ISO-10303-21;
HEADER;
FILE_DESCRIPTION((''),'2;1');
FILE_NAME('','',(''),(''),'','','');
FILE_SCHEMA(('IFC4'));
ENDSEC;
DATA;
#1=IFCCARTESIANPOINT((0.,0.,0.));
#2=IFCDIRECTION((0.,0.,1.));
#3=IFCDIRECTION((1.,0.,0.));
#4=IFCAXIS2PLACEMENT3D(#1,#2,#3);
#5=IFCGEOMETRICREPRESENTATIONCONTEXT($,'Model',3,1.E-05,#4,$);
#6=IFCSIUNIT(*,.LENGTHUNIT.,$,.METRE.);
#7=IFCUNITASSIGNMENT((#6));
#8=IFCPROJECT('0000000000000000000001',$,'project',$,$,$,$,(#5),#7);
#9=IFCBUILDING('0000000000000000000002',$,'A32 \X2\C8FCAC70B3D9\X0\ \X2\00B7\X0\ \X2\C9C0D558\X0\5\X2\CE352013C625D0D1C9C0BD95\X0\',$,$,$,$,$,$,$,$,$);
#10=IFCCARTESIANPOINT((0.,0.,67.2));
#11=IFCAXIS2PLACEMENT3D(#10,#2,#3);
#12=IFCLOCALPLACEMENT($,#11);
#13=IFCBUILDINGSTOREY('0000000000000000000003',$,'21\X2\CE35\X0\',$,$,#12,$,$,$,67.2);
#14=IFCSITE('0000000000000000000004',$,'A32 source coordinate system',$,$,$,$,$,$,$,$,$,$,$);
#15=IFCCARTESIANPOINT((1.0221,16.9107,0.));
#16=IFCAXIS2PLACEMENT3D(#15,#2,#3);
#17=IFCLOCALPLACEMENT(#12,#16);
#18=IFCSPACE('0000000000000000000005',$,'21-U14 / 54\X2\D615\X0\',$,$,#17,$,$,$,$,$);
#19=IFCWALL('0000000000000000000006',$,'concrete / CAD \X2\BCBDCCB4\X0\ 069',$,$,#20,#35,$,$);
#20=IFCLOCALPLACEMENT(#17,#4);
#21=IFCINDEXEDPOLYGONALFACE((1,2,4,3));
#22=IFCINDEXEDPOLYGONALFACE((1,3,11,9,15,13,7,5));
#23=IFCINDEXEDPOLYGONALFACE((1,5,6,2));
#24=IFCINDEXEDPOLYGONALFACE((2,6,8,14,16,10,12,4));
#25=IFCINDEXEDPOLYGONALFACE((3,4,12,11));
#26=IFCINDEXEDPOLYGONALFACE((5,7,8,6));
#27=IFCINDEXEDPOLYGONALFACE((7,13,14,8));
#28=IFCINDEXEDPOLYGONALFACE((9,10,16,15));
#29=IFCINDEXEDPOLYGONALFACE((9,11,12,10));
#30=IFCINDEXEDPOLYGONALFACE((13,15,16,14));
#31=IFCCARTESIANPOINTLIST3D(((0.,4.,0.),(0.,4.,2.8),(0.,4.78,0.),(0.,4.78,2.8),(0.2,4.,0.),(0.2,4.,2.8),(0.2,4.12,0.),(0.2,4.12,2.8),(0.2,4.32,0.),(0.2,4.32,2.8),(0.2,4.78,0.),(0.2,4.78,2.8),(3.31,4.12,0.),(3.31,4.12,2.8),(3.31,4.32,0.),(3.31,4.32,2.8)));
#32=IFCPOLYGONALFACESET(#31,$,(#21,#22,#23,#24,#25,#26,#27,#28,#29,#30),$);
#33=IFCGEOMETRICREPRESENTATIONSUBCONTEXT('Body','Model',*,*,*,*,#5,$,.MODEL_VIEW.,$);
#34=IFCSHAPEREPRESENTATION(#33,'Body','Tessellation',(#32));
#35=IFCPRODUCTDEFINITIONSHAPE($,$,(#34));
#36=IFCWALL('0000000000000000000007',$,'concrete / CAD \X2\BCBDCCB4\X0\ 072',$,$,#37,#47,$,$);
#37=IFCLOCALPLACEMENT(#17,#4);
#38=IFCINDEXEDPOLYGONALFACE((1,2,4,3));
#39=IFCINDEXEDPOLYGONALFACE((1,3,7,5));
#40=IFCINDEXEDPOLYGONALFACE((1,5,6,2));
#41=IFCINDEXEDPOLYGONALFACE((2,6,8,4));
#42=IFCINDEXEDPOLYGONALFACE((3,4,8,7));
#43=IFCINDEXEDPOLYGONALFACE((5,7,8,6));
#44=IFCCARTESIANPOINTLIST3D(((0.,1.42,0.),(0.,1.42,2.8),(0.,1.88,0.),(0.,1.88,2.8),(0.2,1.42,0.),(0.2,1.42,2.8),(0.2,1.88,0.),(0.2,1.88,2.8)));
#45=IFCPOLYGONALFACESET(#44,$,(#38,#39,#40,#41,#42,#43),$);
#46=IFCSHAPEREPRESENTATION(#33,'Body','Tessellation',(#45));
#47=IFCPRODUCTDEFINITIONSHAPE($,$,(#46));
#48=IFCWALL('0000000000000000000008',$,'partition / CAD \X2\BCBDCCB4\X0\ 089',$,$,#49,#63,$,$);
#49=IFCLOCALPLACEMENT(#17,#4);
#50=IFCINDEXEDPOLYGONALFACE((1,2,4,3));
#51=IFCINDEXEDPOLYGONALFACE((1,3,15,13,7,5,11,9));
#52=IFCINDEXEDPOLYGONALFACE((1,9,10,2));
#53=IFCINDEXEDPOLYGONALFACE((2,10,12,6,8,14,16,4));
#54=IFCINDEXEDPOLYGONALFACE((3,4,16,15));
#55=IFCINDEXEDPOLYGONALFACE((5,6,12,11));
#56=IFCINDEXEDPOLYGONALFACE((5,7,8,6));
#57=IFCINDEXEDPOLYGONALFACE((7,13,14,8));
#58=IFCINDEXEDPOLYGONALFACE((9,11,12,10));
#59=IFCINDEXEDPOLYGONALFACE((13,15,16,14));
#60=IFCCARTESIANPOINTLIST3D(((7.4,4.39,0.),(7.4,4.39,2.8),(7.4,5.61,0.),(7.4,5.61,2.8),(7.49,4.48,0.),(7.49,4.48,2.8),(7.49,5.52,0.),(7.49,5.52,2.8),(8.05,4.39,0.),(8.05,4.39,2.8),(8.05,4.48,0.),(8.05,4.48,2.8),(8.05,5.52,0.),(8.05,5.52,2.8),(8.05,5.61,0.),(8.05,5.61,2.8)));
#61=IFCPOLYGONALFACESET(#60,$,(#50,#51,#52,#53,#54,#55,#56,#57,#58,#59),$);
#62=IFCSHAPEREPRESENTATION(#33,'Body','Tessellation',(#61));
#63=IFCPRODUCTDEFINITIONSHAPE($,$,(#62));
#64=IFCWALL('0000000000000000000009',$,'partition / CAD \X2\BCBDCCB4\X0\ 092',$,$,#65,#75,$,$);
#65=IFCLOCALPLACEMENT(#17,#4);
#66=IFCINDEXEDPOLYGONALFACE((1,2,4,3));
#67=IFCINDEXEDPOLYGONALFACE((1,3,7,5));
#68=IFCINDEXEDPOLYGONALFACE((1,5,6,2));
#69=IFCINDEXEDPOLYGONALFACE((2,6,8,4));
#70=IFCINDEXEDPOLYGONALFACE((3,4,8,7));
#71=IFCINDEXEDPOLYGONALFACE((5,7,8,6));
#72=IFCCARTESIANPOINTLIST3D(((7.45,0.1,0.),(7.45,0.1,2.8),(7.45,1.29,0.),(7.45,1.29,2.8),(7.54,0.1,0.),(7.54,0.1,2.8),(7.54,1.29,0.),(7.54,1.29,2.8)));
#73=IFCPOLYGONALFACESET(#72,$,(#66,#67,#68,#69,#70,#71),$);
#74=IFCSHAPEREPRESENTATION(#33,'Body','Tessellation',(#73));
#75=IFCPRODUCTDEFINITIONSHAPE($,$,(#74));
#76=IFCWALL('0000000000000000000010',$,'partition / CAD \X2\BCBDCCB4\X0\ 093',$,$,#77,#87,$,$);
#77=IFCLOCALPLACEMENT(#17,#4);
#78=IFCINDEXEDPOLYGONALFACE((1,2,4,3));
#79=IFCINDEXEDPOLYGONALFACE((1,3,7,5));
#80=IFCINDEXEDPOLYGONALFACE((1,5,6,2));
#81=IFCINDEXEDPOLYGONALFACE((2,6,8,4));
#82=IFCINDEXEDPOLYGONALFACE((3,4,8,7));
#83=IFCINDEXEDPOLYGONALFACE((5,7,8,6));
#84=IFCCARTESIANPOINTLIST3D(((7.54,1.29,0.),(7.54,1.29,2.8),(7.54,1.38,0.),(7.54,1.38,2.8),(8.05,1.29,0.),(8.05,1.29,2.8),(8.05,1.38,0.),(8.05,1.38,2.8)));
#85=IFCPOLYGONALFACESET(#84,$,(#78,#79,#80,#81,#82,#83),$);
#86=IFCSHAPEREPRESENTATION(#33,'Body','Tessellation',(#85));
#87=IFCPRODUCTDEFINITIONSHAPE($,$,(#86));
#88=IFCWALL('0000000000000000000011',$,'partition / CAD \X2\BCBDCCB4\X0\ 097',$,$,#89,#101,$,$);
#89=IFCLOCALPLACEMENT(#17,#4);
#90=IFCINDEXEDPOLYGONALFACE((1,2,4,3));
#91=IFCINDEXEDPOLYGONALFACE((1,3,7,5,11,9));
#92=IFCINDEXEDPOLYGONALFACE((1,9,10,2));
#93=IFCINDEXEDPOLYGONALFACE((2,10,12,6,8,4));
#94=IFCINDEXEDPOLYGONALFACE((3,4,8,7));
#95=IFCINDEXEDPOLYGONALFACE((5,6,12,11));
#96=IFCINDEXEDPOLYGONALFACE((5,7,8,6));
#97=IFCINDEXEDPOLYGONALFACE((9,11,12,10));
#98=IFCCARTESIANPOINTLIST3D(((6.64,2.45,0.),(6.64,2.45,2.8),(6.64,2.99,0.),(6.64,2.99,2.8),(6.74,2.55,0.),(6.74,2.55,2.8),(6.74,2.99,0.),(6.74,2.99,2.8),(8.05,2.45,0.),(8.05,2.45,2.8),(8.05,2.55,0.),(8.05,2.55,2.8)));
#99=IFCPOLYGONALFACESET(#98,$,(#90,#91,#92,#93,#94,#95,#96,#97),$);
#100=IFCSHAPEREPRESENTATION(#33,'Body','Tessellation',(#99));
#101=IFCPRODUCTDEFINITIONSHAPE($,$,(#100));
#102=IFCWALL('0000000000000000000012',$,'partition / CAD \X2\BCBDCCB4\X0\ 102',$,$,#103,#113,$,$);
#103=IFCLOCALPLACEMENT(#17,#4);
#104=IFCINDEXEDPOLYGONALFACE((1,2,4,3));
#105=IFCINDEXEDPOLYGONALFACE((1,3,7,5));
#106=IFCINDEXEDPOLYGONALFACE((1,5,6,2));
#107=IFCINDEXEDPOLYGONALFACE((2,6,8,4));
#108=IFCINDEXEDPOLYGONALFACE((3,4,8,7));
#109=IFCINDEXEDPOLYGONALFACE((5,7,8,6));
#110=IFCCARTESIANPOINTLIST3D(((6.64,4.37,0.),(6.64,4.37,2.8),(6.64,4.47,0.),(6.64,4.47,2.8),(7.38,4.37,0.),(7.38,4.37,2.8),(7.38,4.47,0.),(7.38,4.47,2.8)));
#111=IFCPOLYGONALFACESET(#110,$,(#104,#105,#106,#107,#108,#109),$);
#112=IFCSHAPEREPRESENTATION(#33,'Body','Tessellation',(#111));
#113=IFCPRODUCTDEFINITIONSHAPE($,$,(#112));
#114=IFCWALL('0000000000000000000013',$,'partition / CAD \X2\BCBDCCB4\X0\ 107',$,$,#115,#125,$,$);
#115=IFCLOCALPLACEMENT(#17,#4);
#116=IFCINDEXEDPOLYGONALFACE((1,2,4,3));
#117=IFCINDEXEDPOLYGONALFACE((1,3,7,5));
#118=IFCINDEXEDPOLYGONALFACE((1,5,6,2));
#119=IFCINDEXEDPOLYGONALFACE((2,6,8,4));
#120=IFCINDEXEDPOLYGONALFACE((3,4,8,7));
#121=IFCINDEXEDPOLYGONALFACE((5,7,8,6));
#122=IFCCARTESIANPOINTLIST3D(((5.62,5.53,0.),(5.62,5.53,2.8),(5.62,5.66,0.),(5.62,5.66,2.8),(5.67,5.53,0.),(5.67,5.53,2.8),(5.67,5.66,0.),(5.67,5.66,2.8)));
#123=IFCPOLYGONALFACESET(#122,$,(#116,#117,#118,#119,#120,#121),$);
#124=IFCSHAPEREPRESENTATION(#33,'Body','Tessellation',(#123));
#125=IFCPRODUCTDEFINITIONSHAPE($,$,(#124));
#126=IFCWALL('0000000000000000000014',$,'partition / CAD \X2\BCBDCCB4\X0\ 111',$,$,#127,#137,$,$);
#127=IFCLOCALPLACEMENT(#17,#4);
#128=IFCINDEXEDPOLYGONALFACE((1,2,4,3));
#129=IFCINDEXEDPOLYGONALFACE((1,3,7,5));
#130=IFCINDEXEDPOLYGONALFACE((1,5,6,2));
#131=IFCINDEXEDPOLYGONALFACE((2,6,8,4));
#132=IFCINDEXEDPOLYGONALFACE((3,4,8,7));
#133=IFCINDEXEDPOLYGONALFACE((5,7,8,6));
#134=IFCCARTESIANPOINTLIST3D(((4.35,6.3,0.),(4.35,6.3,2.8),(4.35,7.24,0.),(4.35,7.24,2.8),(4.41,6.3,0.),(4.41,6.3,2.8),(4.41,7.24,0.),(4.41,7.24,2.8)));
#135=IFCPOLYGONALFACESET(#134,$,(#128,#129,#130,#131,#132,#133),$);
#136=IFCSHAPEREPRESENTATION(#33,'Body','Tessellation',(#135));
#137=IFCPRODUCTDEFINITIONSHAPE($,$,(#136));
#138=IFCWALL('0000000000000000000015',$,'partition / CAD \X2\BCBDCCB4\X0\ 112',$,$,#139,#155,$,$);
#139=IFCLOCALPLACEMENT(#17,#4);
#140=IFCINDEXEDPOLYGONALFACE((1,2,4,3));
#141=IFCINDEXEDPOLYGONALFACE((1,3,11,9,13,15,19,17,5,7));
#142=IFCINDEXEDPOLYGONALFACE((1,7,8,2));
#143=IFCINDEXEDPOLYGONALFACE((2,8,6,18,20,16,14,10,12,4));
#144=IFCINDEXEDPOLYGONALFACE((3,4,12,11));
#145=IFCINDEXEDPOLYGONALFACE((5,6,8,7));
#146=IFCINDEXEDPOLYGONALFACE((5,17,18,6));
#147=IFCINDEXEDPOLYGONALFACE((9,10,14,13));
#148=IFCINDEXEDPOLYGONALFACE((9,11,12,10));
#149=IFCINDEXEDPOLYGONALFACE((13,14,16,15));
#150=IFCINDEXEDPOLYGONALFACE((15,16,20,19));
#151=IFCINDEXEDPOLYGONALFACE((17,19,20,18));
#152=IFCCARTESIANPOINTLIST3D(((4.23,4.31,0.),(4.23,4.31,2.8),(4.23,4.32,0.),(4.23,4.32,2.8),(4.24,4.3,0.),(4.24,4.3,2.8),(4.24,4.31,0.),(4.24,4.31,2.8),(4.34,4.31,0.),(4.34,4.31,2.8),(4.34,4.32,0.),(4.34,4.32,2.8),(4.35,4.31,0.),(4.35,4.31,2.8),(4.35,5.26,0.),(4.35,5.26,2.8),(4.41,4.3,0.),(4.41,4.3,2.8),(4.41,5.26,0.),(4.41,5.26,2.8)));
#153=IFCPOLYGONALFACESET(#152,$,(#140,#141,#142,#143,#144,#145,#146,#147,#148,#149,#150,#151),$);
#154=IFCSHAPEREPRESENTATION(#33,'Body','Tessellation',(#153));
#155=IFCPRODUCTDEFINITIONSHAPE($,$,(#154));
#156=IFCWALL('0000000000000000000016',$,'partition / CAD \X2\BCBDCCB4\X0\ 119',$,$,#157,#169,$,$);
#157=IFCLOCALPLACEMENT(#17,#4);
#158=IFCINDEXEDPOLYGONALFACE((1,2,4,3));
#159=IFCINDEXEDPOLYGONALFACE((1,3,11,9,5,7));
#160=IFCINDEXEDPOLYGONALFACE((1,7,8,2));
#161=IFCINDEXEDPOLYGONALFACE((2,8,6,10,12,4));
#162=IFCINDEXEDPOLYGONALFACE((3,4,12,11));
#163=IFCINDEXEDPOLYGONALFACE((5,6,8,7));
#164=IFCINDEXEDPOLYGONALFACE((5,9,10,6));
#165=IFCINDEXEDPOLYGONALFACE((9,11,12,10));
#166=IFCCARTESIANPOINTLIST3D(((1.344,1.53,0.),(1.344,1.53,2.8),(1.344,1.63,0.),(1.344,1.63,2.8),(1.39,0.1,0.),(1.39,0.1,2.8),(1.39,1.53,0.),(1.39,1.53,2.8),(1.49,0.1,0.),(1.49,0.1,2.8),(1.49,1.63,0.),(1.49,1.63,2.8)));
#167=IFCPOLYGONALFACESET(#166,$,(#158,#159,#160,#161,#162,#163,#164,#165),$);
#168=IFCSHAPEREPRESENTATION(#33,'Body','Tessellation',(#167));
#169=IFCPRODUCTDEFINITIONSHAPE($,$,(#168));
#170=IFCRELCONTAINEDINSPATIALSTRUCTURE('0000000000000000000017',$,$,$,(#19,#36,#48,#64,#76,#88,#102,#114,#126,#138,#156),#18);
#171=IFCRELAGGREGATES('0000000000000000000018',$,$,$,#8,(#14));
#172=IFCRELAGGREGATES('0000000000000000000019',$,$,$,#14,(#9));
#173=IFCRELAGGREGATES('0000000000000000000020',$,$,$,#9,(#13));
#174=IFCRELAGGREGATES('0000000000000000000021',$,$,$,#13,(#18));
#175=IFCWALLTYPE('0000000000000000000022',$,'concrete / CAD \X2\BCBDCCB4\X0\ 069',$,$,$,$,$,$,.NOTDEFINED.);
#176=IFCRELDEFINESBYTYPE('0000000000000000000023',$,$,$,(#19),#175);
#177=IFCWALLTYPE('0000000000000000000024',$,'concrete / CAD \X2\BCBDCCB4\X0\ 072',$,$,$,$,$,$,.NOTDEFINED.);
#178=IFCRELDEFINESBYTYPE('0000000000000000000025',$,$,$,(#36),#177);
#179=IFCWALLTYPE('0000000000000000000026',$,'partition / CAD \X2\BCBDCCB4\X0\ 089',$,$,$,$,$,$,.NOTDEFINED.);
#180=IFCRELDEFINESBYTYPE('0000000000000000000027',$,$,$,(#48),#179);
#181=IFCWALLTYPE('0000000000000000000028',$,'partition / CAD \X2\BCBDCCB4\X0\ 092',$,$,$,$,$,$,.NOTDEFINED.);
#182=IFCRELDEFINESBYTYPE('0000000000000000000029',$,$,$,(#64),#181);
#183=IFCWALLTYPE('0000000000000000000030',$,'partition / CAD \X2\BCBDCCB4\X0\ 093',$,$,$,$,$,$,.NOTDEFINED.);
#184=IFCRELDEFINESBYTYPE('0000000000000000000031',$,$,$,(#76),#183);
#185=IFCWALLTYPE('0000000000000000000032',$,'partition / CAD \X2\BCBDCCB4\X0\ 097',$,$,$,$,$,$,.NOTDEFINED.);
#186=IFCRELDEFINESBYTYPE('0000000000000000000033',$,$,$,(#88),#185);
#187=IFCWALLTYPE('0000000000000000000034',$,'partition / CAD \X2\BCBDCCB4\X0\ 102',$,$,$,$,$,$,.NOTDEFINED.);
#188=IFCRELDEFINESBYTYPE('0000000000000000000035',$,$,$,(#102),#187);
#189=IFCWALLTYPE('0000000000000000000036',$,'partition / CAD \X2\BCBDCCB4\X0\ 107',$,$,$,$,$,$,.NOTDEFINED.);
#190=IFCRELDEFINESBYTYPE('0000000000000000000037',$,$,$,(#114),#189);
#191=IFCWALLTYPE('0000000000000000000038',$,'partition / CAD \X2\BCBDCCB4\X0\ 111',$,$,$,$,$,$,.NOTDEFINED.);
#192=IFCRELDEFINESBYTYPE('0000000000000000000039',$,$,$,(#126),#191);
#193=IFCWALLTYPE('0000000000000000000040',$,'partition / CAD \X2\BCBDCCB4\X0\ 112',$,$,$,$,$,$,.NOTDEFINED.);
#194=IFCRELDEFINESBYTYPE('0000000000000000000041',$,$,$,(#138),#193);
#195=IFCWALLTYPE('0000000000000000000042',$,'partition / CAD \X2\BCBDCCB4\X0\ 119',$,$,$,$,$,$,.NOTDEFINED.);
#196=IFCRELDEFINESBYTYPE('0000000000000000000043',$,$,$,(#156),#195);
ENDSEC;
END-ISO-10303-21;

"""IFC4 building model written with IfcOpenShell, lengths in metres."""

from ifc_helpers import new_model, si_unit, frame, origin, origin_with_axes, place, context, subcontext, project, spatial, polyline, outline, extrude, source, transform, mapped, type_object, type_shapes, element, save


model = new_model("IFC4")

# Units and contexts
model_context = context("Model", 3, precision=1e-05, world=origin_with_axes())
body_context = subcontext(model_context, "Body", "Model", "MODEL_VIEW")
ifc_project = project(units=[si_unit("LENGTHUNIT", "METRE")], contexts=[model_context])

# Site, building, storey, space
site = spatial("IfcSite", under=ifc_project, Name="A32 source coordinate system")
building = spatial("IfcBuilding", under=site, Name="A32 주거동 · 지하5층–옥탑지붕")
storey_placement = place(None, frame((0.0, 0.0, 67.2), z_axis=(0.0, 0.0, 1.0), x_axis=(1.0, 0.0, 0.0)))
storey = spatial("IfcBuildingStorey", under=building, at=storey_placement, Name="21층", Elevation=67.2)
space_placement = place(storey_placement, frame((1.0221, 16.9107, 0.0), z_axis=(0.0, 0.0, 1.0), x_axis=(1.0, 0.0, 0.0)))
space = spatial("IfcSpace", under=storey, at=space_placement, Name="21-U14 / 54형")

# Walls
wall_type_1 = type_object("IfcWallType", Name="concrete / CAD 벽체 069", PredefinedType="NOTDEFINED")
shared_shape_1 = source(origin(), body_context, "Body", "SweptSolid", [
    extrude(outline(polyline([(0.2, 4.12), (0.2, 4.0), (0.0, 4.0), (0.0, 4.78), (0.2, 4.78), (0.2, 4.32), (3.31, 4.32), (3.31, 4.12), (0.2, 4.12)])), origin(), (0.0, 0.0, 1.0), 2.8),
])
type_shapes(wall_type_1, [shared_shape_1])
wall_1_placement = place(space_placement, origin_with_axes())
element("IfcWall", 1, at=wall_1_placement, inside=space, type_object=wall_type_1, Name="concrete / CAD 벽체 069", context=body_context, shape_type="MappedRepresentation", body=[
    mapped(shared_shape_1, transform((0.0, 0.0, 0.0), scale=1.0)),
])
wall_type_2 = type_object("IfcWallType", Name="concrete / CAD 벽체 072", PredefinedType="NOTDEFINED")
shared_shape_2 = source(origin(), body_context, "Body", "SweptSolid", [
    extrude(outline(polyline([(0.2, 1.88), (0.2, 1.42), (0.0, 1.42), (0.0, 1.88), (0.2, 1.88)])), origin(), (0.0, 0.0, 1.0), 2.8),
])
type_shapes(wall_type_2, [shared_shape_2])
wall_2_placement = place(space_placement, origin_with_axes())
element("IfcWall", 2, at=wall_2_placement, inside=space, type_object=wall_type_2, Name="concrete / CAD 벽체 072", context=body_context, shape_type="MappedRepresentation", body=[
    mapped(shared_shape_2, transform((0.0, 0.0, 0.0), scale=1.0)),
])
wall_type_3 = type_object("IfcWallType", Name="partition / CAD 벽체 089", PredefinedType="NOTDEFINED")
shared_shape_3 = source(origin(), body_context, "Body", "SweptSolid", [
    extrude(outline(polyline([(7.49, 4.48), (8.05, 4.48), (8.05, 4.39), (7.4, 4.39), (7.4, 5.61), (8.05, 5.61), (8.05, 5.52), (7.49, 5.52), (7.49, 4.48)])), origin(), (0.0, 0.0, 1.0), 2.8),
])
type_shapes(wall_type_3, [shared_shape_3])
wall_3_placement = place(space_placement, origin_with_axes())
element("IfcWall", 3, at=wall_3_placement, inside=space, type_object=wall_type_3, Name="partition / CAD 벽체 089", context=body_context, shape_type="MappedRepresentation", body=[
    mapped(shared_shape_3, transform((0.0, 0.0, 0.0), scale=1.0)),
])
wall_type_4 = type_object("IfcWallType", Name="partition / CAD 벽체 092", PredefinedType="NOTDEFINED")
shared_shape_4 = source(origin(), body_context, "Body", "SweptSolid", [
    extrude(outline(polyline([(7.54, 1.29), (7.54, 0.1), (7.45, 0.1), (7.45, 1.29), (7.54, 1.29)])), origin(), (0.0, 0.0, 1.0), 2.8),
])
type_shapes(wall_type_4, [shared_shape_4])
wall_4_placement = place(space_placement, origin_with_axes())
element("IfcWall", 4, at=wall_4_placement, inside=space, type_object=wall_type_4, Name="partition / CAD 벽체 092", context=body_context, shape_type="MappedRepresentation", body=[
    mapped(shared_shape_4, transform((0.0, 0.0, 0.0), scale=1.0)),
])
wall_type_5 = type_object("IfcWallType", Name="partition / CAD 벽체 093", PredefinedType="NOTDEFINED")
shared_shape_5 = source(origin(), body_context, "Body", "SweptSolid", [
    extrude(outline(polyline([(8.05, 1.29), (7.54, 1.29), (7.54, 1.38), (8.05, 1.38), (8.05, 1.29)])), origin(), (0.0, 0.0, 1.0), 2.8),
])
type_shapes(wall_type_5, [shared_shape_5])
wall_5_placement = place(space_placement, origin_with_axes())
element("IfcWall", 5, at=wall_5_placement, inside=space, type_object=wall_type_5, Name="partition / CAD 벽체 093", context=body_context, shape_type="MappedRepresentation", body=[
    mapped(shared_shape_5, transform((0.0, 0.0, 0.0), scale=1.0)),
])
wall_type_6 = type_object("IfcWallType", Name="partition / CAD 벽체 097", PredefinedType="NOTDEFINED")
shared_shape_6 = source(origin(), body_context, "Body", "SweptSolid", [
    extrude(outline(polyline([(8.05, 2.45), (6.64, 2.45), (6.64, 2.99), (6.74, 2.99), (6.74, 2.55), (8.05, 2.55), (8.05, 2.45)])), origin(), (0.0, 0.0, 1.0), 2.8),
])
type_shapes(wall_type_6, [shared_shape_6])
wall_6_placement = place(space_placement, origin_with_axes())
element("IfcWall", 6, at=wall_6_placement, inside=space, type_object=wall_type_6, Name="partition / CAD 벽체 097", context=body_context, shape_type="MappedRepresentation", body=[
    mapped(shared_shape_6, transform((0.0, 0.0, 0.0), scale=1.0)),
])
wall_type_7 = type_object("IfcWallType", Name="partition / CAD 벽체 102", PredefinedType="NOTDEFINED")
shared_shape_7 = source(origin(), body_context, "Body", "SweptSolid", [
    extrude(outline(polyline([(7.38, 4.47), (7.38, 4.37), (6.64, 4.37), (6.64, 4.47), (7.38, 4.47)])), origin(), (0.0, 0.0, 1.0), 2.8),
])
type_shapes(wall_type_7, [shared_shape_7])
wall_7_placement = place(space_placement, origin_with_axes())
element("IfcWall", 7, at=wall_7_placement, inside=space, type_object=wall_type_7, Name="partition / CAD 벽체 102", context=body_context, shape_type="MappedRepresentation", body=[
    mapped(shared_shape_7, transform((0.0, 0.0, 0.0), scale=1.0)),
])
wall_type_8 = type_object("IfcWallType", Name="partition / CAD 벽체 107", PredefinedType="NOTDEFINED")
shared_shape_8 = source(origin(), body_context, "Body", "SweptSolid", [
    extrude(outline(polyline([(5.62, 5.53), (5.62, 5.66), (5.67, 5.66), (5.67, 5.53), (5.62, 5.53)])), origin(), (0.0, 0.0, 1.0), 2.8),
])
type_shapes(wall_type_8, [shared_shape_8])
wall_8_placement = place(space_placement, origin_with_axes())
element("IfcWall", 8, at=wall_8_placement, inside=space, type_object=wall_type_8, Name="partition / CAD 벽체 107", context=body_context, shape_type="MappedRepresentation", body=[
    mapped(shared_shape_8, transform((0.0, 0.0, 0.0), scale=1.0)),
])
wall_type_9 = type_object("IfcWallType", Name="partition / CAD 벽체 111", PredefinedType="NOTDEFINED")
shared_shape_9 = source(origin(), body_context, "Body", "SweptSolid", [
    extrude(outline(polyline([(4.41, 7.24), (4.41, 6.3), (4.35, 6.3), (4.35, 7.24), (4.41, 7.24)])), origin(), (0.0, 0.0, 1.0), 2.8),
])
type_shapes(wall_type_9, [shared_shape_9])
wall_9_placement = place(space_placement, origin_with_axes())
element("IfcWall", 9, at=wall_9_placement, inside=space, type_object=wall_type_9, Name="partition / CAD 벽체 111", context=body_context, shape_type="MappedRepresentation", body=[
    mapped(shared_shape_9, transform((0.0, 0.0, 0.0), scale=1.0)),
])
wall_type_10 = type_object("IfcWallType", Name="partition / CAD 벽체 112", PredefinedType="NOTDEFINED")
shared_shape_10 = source(origin(), body_context, "Body", "SweptSolid", [
    extrude(outline(polyline([(4.24, 4.3), (4.24, 4.31), (4.23, 4.31), (4.23, 4.32), (4.34, 4.32), (4.34, 4.31), (4.35, 4.31), (4.35, 5.26), (4.41, 5.26), (4.41, 4.3), (4.24, 4.3)])), origin(), (0.0, 0.0, 1.0), 2.8),
])
type_shapes(wall_type_10, [shared_shape_10])
wall_10_placement = place(space_placement, origin_with_axes())
element("IfcWall", 10, at=wall_10_placement, inside=space, type_object=wall_type_10, Name="partition / CAD 벽체 112", context=body_context, shape_type="MappedRepresentation", body=[
    mapped(shared_shape_10, transform((0.0, 0.0, 0.0), scale=1.0)),
])
wall_type_11 = type_object("IfcWallType", Name="partition / CAD 벽체 119", PredefinedType="NOTDEFINED")
shared_shape_11 = source(origin(), body_context, "Body", "SweptSolid", [
    extrude(outline(polyline([(1.344, 1.53), (1.344, 1.63), (1.49, 1.63), (1.49, 0.1), (1.39, 0.1), (1.39, 1.53), (1.344, 1.53)])), origin(), (0.0, 0.0, 1.0), 2.8),
])
type_shapes(wall_type_11, [shared_shape_11])
wall_11_placement = place(space_placement, origin_with_axes())
element("IfcWall", 11, at=wall_11_placement, inside=space, type_object=wall_type_11, Name="partition / CAD 벽체 119", context=body_context, shape_type="MappedRepresentation", body=[
    mapped(shared_shape_11, transform((0.0, 0.0, 0.0), scale=1.0)),
])

save(model, "model.ifc")
